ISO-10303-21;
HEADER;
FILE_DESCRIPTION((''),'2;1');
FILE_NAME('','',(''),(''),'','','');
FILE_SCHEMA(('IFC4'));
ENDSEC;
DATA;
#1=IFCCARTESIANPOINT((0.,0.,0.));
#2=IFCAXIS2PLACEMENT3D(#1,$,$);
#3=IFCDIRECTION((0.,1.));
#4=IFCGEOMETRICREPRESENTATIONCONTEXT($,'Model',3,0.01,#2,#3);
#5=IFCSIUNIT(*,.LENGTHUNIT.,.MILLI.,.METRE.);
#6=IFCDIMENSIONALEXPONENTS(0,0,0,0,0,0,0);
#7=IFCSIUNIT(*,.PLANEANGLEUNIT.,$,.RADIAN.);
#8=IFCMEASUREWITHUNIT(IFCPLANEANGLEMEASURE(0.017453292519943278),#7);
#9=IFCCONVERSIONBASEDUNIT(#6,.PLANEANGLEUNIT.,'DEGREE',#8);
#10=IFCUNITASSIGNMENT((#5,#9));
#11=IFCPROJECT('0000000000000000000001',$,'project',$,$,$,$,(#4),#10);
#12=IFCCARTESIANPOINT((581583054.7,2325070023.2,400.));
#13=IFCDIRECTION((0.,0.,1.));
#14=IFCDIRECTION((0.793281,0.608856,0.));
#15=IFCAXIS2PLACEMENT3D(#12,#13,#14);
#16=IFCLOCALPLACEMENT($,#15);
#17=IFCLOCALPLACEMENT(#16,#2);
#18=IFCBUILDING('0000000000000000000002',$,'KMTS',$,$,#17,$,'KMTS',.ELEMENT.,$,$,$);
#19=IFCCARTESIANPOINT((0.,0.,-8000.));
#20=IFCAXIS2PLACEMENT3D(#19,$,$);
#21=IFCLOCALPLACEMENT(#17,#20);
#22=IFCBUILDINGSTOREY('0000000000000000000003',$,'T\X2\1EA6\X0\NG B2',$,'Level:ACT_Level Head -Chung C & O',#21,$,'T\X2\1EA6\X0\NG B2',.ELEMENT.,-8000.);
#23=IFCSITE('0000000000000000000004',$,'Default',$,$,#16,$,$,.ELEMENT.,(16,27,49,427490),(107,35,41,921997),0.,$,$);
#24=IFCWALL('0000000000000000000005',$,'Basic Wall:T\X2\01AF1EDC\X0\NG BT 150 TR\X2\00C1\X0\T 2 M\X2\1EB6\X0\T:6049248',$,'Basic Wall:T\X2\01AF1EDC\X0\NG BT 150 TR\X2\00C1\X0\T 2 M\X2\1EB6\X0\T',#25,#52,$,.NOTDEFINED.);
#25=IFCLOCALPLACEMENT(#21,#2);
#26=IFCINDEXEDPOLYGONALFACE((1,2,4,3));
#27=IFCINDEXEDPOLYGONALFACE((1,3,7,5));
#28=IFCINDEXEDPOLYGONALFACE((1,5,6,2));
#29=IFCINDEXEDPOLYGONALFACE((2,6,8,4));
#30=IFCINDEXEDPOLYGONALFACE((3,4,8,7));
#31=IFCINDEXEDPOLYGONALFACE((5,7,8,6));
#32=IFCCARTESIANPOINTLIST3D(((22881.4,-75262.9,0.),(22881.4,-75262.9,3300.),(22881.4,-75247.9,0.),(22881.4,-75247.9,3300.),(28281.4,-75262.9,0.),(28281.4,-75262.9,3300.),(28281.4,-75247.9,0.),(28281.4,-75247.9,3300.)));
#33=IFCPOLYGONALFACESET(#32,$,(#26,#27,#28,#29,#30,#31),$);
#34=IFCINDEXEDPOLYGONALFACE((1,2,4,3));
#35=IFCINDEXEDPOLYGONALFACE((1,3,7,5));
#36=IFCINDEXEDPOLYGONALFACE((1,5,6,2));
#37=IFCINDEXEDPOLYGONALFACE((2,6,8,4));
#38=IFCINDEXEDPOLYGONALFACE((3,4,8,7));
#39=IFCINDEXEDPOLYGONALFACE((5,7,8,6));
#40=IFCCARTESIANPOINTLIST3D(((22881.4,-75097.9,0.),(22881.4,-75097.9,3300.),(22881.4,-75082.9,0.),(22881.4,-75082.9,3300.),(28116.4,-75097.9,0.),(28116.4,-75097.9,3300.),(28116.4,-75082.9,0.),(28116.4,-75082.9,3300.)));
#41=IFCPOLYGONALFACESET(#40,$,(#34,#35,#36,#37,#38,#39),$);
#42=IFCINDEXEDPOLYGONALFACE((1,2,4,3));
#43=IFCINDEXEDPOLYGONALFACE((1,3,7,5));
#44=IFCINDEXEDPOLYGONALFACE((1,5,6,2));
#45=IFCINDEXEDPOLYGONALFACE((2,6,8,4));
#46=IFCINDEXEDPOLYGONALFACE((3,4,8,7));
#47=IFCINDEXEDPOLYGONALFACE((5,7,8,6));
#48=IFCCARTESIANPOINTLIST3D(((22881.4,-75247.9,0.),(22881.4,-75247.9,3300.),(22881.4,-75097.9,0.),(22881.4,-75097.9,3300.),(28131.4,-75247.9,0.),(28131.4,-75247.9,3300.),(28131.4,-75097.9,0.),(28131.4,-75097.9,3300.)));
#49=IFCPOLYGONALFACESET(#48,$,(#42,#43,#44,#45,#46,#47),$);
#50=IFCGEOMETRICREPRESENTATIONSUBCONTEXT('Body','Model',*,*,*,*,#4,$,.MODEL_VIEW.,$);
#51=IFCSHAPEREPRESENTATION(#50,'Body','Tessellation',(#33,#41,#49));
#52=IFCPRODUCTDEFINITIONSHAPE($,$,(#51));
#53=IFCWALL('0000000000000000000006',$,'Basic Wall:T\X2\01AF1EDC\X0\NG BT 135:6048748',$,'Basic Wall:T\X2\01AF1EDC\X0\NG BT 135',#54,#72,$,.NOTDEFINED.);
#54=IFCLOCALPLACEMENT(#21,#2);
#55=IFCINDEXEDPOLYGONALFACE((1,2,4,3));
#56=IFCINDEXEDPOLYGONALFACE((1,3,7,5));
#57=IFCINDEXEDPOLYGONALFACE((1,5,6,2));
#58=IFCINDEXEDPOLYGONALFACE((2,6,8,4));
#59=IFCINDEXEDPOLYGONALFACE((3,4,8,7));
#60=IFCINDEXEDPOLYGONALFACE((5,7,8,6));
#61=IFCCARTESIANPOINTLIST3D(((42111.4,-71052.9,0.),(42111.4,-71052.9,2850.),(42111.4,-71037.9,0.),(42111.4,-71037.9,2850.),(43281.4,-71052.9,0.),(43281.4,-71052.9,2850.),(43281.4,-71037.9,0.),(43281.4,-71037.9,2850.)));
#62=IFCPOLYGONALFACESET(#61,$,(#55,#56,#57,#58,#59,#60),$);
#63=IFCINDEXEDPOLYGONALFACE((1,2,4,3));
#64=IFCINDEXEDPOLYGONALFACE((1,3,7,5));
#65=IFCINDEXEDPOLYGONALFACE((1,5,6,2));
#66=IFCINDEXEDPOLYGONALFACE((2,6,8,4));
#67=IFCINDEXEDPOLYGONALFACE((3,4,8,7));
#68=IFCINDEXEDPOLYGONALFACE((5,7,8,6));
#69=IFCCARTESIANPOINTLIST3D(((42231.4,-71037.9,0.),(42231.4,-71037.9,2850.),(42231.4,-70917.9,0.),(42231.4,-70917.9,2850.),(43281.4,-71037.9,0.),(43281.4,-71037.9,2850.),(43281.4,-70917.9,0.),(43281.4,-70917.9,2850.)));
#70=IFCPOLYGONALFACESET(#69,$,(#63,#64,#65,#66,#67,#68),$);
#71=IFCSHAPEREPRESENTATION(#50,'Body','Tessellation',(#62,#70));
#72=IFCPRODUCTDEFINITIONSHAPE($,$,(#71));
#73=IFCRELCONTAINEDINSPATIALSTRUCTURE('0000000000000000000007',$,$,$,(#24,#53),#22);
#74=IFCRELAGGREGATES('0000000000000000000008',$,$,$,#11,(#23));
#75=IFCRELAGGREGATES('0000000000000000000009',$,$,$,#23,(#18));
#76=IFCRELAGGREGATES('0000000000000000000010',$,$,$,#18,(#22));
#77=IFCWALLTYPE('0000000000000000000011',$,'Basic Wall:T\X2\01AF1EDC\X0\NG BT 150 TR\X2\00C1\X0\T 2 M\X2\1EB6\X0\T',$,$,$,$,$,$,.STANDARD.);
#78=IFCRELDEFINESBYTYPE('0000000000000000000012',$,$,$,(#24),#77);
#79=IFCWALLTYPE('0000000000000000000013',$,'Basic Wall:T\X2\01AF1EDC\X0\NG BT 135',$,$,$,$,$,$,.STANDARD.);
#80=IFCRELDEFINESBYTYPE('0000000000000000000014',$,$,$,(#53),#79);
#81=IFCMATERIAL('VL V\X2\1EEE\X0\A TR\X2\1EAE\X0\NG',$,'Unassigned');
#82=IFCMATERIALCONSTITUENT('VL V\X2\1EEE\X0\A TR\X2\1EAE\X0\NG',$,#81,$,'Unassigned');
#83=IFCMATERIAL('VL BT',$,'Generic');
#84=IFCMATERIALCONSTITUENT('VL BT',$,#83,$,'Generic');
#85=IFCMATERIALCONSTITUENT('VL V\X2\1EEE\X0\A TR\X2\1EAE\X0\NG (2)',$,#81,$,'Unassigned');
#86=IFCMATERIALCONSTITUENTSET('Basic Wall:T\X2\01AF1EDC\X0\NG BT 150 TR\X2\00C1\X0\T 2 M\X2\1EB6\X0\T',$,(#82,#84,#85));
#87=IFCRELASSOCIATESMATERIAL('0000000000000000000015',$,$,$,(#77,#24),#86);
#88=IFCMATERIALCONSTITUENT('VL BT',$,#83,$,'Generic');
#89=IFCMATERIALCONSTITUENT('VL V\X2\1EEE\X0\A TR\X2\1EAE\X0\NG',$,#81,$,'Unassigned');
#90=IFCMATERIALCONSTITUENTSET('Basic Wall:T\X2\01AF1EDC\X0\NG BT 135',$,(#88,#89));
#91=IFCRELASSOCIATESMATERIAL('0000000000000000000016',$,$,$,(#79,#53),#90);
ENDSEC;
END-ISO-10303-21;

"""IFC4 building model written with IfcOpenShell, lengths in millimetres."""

from ifc_helpers import new_model, entity, si_unit, converted_unit, direction, frame, origin, place, context, subcontext, project, spatial, indexed_curve, outline, extrude, material, constituent, constituent_set, type_object, element, save


model = new_model("IFC4")

# Units and contexts
model_context = context("Model", 3, precision=0.01, world=origin(), true_north=direction((0.0, 1.0)))
body_context = subcontext(model_context, "Body", "Model", "MODEL_VIEW")
ifc_project = project(units=[si_unit("LENGTHUNIT", "METRE", prefix="MILLI"), converted_unit("PLANEANGLEUNIT", "DEGREE", entity("IfcPlaneAngleMeasure", 0.017453292519943278), si_unit("PLANEANGLEUNIT", "RADIAN"), dimensions=[0, 0, 0, 0, 0, 0, 0])], contexts=[model_context])

# Site, building, storey
site_placement = place(None, frame((581583054.7, 2325070023.2, 400.0), z_axis=(0.0, 0.0, 1.0), x_axis=(0.793281, 0.608856, 0.0)))
site = spatial("IfcSite", under=ifc_project, at=site_placement, Name="Default", CompositionType="ELEMENT", RefLatitude=(16, 27, 49, 427490), RefLongitude=(107, 35, 41, 921997), RefElevation=0.0)
building_placement = place(site_placement, origin())
building = spatial("IfcBuilding", under=site, at=building_placement, Name="KMTS", LongName="KMTS", CompositionType="ELEMENT")
storey_placement = place(building_placement, frame((0.0, 0.0, -8000.0)))
storey = spatial("IfcBuildingStorey", under=building, at=storey_placement, Name="TẦNG B2", ObjectType="Level:ACT_Level Head -Chung C & O", LongName="TẦNG B2", CompositionType="ELEMENT", Elevation=-8000.0)

# Shared definitions
ifc_material_1 = material(Name="VL VỮA TRẮNG", Category="Unassigned")
ifc_constituent_1 = constituent(ifc_material_1, Name="VL VỮA TRẮNG", Category="Unassigned")
ifc_material_2 = material(Name="VL BT", Category="Generic")
ifc_constituent_2 = constituent(ifc_material_2, Name="VL BT", Category="Generic")
ifc_constituent_3 = constituent(ifc_material_1, Name="VL VỮA TRẮNG (2)", Category="Unassigned")
ifc_constituent_set_1 = constituent_set(constituents=[ifc_constituent_1, ifc_constituent_2, ifc_constituent_3], Name="Basic Wall:TƯỜNG BT 150 TRÁT 2 MẶT")
wall_type_1 = type_object("IfcWallType", Name="Basic Wall:TƯỜNG BT 150 TRÁT 2 MẶT", PredefinedType="STANDARD", material=ifc_constituent_set_1)

# Walls
wall_1_placement = place(storey_placement, frame((22881.4, -75172.9, 0.0)))
element("IfcWall", 1, at=wall_1_placement, inside=storey, type_object=wall_type_1, material=ifc_constituent_set_1, Name="Basic Wall:TƯỜNG BT 150 TRÁT 2 MẶT:6049248", ObjectType="Basic Wall:TƯỜNG BT 150 TRÁT 2 MẶT", PredefinedType="NOTDEFINED", context=body_context, shape_type="SweptSolid", body=[
    extrude(outline(indexed_curve([(-7.5, -2700.0), (7.5, -2700.0), (7.5, 2700.0), (-7.5, 2700.0), (-7.5, -2700.0)], self_intersect=False)), frame((2700.0, -82.5, 0.0), z_axis=(0.0, 0.0, 1.0), x_axis=(0.0, 1.0, 0.0)), (0.0, 0.0, 1.0), 3300.0),
    extrude(outline(indexed_curve([(-7.5, -2617.5), (7.5, -2617.5), (7.5, 2617.5), (-7.5, 2617.5), (-7.5, -2617.5)], self_intersect=False)), frame((2617.5, 82.5, 0.0), z_axis=(0.0, 0.0, 1.0), x_axis=(0.0, -1.0, 0.0)), (0.0, 0.0, 1.0), 3300.0),
    extrude(outline(indexed_curve([(-2625.0, -75.0), (2625.0, -75.0), (2625.0, 75.0), (-2625.0, 75.0), (-2625.0, -75.0)], self_intersect=False)), frame((2625.0, 0.0, 0.0)), (0.0, 0.0, 1.0), 3300.0),
])
ifc_constituent_4 = constituent(ifc_material_2, Name="VL BT", Category="Generic")
ifc_constituent_5 = constituent(ifc_material_1, Name="VL VỮA TRẮNG", Category="Unassigned")
ifc_constituent_set_2 = constituent_set(constituents=[ifc_constituent_4, ifc_constituent_5], Name="Basic Wall:TƯỜNG BT 135")
wall_type_2 = type_object("IfcWallType", Name="Basic Wall:TƯỜNG BT 135", PredefinedType="STANDARD", material=ifc_constituent_set_2)
wall_2_placement = place(storey_placement, frame((42231.4, -70985.4, 0.0)))
element("IfcWall", 2, at=wall_2_placement, inside=storey, type_object=wall_type_2, material=ifc_constituent_set_2, Name="Basic Wall:TƯỜNG BT 135:6048748", ObjectType="Basic Wall:TƯỜNG BT 135", PredefinedType="NOTDEFINED", context=body_context, shape_type="SweptSolid", body=[
    extrude(outline(indexed_curve([(-7.5, -585.0), (7.5, -585.0), (7.5, 585.0), (-7.5, 585.0), (-7.5, -585.0)], self_intersect=False)), frame((465.0, -60.0, 0.0), z_axis=(0.0, 0.0, 1.0), x_axis=(0.0, 1.0, 0.0)), (0.0, 0.0, 1.0), 2850.0),
    extrude(outline(indexed_curve([(-60.0, -525.0), (60.0, -525.0), (60.0, 525.0), (-60.0, 525.0), (-60.0, -525.0)], self_intersect=False)), frame((525.0, 7.5, 0.0), z_axis=(0.0, 0.0, 1.0), x_axis=(0.0, -1.0, 0.0)), (0.0, 0.0, 1.0), 2850.0),
])

save(model, "model.ifc")
